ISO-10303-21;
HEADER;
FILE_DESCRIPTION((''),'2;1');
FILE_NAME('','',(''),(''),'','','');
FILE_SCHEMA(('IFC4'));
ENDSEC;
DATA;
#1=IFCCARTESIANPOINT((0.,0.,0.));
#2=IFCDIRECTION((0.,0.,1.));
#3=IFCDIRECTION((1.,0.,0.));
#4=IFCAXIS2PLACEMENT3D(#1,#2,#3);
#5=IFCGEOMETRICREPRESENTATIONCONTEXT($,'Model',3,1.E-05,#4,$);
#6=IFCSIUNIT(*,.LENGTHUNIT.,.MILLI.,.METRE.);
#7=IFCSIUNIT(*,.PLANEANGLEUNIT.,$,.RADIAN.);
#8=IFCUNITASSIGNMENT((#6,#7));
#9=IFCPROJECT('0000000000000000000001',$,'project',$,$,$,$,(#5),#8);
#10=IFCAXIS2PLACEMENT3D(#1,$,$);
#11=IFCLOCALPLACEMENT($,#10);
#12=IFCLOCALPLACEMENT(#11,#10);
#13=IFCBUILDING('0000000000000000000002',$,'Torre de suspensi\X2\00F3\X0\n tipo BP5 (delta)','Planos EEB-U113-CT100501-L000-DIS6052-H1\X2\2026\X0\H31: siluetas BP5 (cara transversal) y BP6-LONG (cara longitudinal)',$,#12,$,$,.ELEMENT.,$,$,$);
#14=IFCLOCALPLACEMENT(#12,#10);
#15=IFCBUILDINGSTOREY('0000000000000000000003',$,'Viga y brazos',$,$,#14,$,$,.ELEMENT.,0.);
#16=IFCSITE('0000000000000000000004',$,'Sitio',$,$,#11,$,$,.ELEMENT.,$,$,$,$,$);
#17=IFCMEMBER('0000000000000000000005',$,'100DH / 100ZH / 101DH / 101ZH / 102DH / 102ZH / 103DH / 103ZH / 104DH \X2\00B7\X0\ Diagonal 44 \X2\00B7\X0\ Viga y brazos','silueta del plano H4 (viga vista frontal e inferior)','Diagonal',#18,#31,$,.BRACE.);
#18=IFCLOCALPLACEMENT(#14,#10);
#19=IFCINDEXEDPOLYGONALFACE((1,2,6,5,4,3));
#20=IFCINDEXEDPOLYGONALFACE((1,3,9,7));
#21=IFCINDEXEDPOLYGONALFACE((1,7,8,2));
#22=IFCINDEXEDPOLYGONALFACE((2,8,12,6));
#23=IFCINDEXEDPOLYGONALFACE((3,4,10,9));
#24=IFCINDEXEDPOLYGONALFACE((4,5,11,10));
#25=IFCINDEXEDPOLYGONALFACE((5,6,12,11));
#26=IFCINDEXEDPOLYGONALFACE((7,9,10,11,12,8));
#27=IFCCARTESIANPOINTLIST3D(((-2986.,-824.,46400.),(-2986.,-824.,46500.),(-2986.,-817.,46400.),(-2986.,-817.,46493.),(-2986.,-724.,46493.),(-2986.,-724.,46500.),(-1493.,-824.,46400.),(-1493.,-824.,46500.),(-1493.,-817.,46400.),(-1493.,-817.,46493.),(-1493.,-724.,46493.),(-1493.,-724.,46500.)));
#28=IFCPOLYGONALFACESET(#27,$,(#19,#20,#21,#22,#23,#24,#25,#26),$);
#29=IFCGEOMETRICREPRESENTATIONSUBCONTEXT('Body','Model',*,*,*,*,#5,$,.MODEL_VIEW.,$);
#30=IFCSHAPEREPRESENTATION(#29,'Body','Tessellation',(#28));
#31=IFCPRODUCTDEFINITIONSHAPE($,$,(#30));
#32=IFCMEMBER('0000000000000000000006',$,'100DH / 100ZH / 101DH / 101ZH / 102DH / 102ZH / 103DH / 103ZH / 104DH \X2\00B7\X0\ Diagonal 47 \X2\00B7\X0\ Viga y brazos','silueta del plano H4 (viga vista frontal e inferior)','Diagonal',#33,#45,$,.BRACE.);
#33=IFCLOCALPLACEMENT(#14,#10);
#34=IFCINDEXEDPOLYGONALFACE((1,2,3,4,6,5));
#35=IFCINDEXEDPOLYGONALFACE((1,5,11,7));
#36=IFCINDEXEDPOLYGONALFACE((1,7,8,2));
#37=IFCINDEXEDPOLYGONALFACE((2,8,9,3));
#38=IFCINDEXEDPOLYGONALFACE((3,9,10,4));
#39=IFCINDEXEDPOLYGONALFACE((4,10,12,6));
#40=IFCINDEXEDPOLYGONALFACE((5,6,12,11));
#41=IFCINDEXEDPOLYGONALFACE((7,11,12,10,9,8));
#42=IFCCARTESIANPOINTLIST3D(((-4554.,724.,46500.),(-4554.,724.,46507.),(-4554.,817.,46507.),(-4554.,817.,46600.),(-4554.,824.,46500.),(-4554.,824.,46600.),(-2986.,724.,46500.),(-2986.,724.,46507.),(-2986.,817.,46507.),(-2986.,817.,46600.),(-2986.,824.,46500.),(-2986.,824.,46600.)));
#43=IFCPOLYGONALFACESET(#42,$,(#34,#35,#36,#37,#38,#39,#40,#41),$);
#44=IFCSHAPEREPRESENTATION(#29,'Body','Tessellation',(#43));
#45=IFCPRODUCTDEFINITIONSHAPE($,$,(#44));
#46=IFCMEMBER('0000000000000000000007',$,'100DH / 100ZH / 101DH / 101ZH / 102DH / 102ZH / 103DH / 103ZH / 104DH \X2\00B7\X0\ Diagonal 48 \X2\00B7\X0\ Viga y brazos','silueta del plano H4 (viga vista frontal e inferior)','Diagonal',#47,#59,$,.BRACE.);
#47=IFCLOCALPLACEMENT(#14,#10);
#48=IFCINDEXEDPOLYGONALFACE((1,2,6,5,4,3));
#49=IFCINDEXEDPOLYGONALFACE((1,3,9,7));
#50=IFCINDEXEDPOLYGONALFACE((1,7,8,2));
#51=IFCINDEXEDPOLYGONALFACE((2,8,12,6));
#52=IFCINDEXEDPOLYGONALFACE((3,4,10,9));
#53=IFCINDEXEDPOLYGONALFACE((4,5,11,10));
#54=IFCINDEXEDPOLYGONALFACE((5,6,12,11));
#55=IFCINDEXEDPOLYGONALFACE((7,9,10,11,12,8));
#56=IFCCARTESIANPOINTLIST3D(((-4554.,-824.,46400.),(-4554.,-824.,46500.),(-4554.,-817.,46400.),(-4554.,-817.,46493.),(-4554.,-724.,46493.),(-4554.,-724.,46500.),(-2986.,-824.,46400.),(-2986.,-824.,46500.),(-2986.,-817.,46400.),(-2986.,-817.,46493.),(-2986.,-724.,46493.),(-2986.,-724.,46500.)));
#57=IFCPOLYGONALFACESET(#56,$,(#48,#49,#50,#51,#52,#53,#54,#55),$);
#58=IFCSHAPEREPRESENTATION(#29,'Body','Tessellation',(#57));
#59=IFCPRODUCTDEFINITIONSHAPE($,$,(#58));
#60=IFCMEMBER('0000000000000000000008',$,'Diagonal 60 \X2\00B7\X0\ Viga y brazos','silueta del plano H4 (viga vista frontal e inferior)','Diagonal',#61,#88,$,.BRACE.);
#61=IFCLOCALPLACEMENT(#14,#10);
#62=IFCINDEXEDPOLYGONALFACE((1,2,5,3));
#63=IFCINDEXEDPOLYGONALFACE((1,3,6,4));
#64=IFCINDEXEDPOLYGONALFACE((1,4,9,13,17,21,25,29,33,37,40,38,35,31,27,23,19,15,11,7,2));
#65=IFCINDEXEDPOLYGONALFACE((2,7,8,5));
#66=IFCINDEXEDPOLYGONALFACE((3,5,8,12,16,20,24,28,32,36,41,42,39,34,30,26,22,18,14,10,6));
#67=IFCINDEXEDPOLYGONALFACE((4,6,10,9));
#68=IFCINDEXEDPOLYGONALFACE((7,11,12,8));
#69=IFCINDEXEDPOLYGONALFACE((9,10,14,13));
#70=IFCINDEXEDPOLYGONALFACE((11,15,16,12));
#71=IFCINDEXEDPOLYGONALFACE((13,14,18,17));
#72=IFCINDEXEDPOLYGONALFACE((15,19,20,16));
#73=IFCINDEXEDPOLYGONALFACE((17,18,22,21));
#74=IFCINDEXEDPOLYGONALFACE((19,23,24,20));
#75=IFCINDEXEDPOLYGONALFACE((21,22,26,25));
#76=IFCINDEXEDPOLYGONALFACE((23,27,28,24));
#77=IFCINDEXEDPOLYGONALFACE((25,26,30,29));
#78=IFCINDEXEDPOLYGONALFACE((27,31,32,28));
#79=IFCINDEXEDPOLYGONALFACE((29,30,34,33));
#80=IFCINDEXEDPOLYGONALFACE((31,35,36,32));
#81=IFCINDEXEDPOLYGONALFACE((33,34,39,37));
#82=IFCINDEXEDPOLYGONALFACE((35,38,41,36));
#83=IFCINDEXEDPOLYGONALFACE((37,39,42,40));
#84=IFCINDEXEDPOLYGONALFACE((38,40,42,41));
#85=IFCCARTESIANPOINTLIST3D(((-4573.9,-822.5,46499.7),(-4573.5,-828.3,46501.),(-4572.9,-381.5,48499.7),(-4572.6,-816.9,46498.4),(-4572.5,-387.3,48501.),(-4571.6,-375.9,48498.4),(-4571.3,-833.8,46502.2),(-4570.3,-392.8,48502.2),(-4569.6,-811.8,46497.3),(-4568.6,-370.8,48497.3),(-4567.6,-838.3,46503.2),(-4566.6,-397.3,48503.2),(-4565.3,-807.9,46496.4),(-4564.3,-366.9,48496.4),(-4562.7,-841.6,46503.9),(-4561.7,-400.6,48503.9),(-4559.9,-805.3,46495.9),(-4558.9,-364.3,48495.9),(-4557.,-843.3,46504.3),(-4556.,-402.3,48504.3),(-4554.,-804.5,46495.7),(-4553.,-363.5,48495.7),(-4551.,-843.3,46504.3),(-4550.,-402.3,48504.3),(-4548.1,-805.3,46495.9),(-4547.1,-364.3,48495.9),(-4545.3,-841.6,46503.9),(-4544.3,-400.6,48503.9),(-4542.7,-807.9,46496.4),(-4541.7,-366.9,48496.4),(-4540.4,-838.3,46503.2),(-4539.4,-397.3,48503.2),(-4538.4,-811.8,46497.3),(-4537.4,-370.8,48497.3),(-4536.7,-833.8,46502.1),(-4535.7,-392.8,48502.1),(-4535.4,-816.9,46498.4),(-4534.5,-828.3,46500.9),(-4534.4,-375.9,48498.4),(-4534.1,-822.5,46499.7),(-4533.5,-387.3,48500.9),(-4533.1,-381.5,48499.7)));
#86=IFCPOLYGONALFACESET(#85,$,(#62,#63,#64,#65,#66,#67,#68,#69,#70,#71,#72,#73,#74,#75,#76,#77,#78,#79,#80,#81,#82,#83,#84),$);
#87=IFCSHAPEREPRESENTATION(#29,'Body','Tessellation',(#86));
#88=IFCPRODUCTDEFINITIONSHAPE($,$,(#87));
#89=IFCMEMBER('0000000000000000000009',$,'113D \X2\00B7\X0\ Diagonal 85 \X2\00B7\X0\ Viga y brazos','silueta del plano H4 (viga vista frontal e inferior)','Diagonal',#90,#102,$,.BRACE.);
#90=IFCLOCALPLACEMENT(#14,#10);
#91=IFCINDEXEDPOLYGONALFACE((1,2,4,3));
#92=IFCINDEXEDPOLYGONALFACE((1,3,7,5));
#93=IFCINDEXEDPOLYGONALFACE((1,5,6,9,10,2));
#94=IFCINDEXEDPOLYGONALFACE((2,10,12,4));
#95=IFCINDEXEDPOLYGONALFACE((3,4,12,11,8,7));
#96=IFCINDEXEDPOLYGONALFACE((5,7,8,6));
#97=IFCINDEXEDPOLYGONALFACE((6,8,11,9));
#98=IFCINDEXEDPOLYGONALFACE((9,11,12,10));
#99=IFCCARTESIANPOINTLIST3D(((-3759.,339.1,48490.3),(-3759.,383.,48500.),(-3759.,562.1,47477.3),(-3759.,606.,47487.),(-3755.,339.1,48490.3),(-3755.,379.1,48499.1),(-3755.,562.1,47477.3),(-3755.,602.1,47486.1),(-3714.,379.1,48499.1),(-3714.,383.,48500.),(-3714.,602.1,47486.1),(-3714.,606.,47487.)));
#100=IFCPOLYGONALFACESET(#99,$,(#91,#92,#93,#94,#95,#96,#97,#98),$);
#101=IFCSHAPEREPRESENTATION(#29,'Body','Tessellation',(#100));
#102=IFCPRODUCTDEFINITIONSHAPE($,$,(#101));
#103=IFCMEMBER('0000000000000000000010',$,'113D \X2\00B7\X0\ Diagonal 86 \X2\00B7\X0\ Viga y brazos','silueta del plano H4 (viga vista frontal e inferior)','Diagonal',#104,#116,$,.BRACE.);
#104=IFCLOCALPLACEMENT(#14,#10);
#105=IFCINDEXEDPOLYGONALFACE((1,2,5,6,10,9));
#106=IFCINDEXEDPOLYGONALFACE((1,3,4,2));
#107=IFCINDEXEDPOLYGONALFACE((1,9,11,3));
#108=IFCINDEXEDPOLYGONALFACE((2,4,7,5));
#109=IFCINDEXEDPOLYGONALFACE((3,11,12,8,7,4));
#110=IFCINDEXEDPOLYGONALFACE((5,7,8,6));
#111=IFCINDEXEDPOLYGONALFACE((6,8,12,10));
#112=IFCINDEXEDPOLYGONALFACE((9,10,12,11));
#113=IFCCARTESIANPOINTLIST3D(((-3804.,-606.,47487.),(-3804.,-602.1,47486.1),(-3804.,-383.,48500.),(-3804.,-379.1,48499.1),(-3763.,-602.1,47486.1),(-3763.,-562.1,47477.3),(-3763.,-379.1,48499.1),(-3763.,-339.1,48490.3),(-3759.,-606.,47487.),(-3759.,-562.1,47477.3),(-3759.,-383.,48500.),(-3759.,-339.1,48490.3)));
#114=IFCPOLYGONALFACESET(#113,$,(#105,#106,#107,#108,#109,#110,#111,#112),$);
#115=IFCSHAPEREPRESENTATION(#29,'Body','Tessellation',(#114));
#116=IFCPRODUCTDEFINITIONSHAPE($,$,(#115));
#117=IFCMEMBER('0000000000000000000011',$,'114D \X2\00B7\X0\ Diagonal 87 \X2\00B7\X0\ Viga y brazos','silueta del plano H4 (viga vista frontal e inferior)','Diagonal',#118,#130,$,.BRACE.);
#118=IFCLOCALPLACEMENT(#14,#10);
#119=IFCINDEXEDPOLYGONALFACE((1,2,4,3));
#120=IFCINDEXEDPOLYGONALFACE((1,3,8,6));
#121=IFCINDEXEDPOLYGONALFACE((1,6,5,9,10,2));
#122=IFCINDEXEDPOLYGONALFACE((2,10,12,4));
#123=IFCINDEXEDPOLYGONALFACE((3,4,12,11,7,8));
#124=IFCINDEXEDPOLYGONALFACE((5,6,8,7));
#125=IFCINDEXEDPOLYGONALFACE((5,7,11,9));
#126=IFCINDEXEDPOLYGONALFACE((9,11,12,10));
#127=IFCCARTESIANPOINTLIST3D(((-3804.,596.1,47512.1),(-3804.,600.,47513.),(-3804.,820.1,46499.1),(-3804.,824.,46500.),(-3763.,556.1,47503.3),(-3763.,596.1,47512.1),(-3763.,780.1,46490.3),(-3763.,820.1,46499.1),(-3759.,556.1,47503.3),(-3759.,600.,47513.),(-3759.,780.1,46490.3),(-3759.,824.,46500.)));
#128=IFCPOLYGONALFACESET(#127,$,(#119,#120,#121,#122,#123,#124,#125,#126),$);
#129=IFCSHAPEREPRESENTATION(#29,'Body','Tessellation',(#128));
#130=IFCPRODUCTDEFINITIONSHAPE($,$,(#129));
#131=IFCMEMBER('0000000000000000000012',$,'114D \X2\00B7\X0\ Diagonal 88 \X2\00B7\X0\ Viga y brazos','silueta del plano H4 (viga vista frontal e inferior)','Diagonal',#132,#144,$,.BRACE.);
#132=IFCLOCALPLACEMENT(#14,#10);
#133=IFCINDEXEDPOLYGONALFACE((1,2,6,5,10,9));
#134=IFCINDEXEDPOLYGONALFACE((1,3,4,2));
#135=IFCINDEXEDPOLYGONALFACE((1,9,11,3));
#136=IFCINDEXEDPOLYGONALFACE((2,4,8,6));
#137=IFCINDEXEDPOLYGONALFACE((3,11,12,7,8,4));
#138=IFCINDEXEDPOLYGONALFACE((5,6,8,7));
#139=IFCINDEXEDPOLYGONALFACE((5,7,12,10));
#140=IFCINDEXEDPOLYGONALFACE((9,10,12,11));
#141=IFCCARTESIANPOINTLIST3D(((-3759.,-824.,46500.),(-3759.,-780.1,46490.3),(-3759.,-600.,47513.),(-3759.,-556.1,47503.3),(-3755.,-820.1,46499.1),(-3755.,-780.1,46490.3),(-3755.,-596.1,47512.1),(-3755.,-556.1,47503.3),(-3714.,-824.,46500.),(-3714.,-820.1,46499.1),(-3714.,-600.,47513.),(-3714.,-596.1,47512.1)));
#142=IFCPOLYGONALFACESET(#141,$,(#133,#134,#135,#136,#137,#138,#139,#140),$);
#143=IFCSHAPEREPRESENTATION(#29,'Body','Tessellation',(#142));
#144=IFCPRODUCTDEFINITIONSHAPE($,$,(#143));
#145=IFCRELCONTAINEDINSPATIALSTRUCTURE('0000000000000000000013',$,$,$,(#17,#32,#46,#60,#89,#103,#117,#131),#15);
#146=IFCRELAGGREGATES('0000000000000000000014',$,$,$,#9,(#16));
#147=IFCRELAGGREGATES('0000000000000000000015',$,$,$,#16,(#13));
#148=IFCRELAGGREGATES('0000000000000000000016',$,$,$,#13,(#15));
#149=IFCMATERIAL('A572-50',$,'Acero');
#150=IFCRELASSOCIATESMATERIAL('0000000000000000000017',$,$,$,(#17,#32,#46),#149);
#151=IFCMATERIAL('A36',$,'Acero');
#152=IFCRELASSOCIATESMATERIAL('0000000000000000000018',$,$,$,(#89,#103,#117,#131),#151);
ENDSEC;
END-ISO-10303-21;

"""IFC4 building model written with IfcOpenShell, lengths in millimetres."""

from ifc_helpers import new_model, si_unit, frame, frame_2d, origin, origin_with_axes, place, context, subcontext, project, spatial, circle, l_section, extrude, material, element, save


model = new_model("IFC4")

# Units and contexts
model_context = context("Model", 3, precision=1e-05, world=origin_with_axes())
body_context = subcontext(model_context, "Body", "Model", "MODEL_VIEW")
ifc_project = project(units=[si_unit("LENGTHUNIT", "METRE", prefix="MILLI"), si_unit("PLANEANGLEUNIT", "RADIAN")], contexts=[model_context])

# Site, building, storey
site_placement = place(None, origin())
site = spatial("IfcSite", under=ifc_project, at=site_placement, Name="Sitio", CompositionType="ELEMENT")
building_placement = place(site_placement, origin())
building = spatial("IfcBuilding", under=site, at=building_placement, Name="Torre de suspensión tipo BP5 (delta)", Description="Planos EEB-U113-CT100501-L000-DIS6052-H1…H31: siluetas BP5 (cara transversal) y BP6-LONG (cara longitudinal)", CompositionType="ELEMENT")
storey_placement = place(building_placement, origin())
storey = spatial("IfcBuildingStorey", under=building, at=storey_placement, Name="Viga y brazos", CompositionType="ELEMENT", Elevation=0.0)

# Members
ifc_material_1 = material(Name="A572-50", Category="Acero")
for number, where, z_axis, x_axis, name in (
    (1, (-1493.0, -824.0, 46500.0), (-1.0, 0.0, 0.0), (0.0, 1.0, 0.0), "100DH / 100ZH / 101DH / 101ZH / 102DH / 102ZH / 103DH / 103ZH / 104DH · Diagonal 44 · Viga y brazos"),
):
    element("IfcMember", number, at=place(storey_placement, frame(where, z_axis=z_axis, x_axis=x_axis)), inside=storey, material=ifc_material_1, Name=name, Description="silueta del plano H4 (viga vista frontal e inferior)", ObjectType="Diagonal", PredefinedType="BRACE", context=body_context, shape_type="SweptSolid", body=[
        extrude(l_section(Depth=100.0, Width=100.0, Thickness=7.0, at=frame_2d((50.0, 50.0))), None, (0.0, 0.0, 1.0), 1493.0),
    ])
for number, where, z_axis, x_axis, name in (
    (2, (-2986.0, 824.0, 46500.0), (-1.0, 0.0, 0.0), (0.0, -1.0, 0.0), "100DH / 100ZH / 101DH / 101ZH / 102DH / 102ZH / 103DH / 103ZH / 104DH · Diagonal 47 · Viga y brazos"),
    (3, (-2986.0, -824.0, 46500.0), (-1.0, 0.0, 0.0), (0.0, 1.0, 0.0), "100DH / 100ZH / 101DH / 101ZH / 102DH / 102ZH / 103DH / 103ZH / 104DH · Diagonal 48 · Viga y brazos"),
):
    element("IfcMember", number, at=place(storey_placement, frame(where, z_axis=z_axis, x_axis=x_axis)), inside=storey, material=ifc_material_1, Name=name, Description="silueta del plano H4 (viga vista frontal e inferior)", ObjectType="Diagonal", PredefinedType="BRACE", context=body_context, shape_type="SweptSolid", body=[
        extrude(l_section(Depth=100.0, Width=100.0, Thickness=7.0, at=frame_2d((50.0, 50.0))), None, (0.0, 0.0, 1.0), 1568.0),
    ])
member_placement = place(storey_placement, frame((-4553.0, -383.0, 48500.0), z_axis=(-0.000488, -0.215327, -0.976542), x_axis=(-0.000108, 0.976542, -0.215327)))
element("IfcMember", 4, at=member_placement, inside=storey, Name="Diagonal 60 · Viga y brazos", Description="silueta del plano H4 (viga vista frontal e inferior)", ObjectType="Diagonal", PredefinedType="BRACE", context=body_context, shape_type="SweptSolid", body=[
    extrude(circle(Radius=20.0), None, (0.0, 0.0, 1.0), 2048.0),
])
ifc_material_2 = material(Name="A36", Category="Acero")
for number, where, z_axis, x_axis, name in (
    (5, (-3759.0, 606.0, 47487.0), (0.0, -0.214991, 0.976616), (0.0, -0.976616, -0.214991), "113D · Diagonal 85 · Viga y brazos"),
    (6, (-3759.0, -606.0, 47487.0), (0.0, 0.214991, 0.976616), (0.0, 0.976616, -0.214991), "113D · Diagonal 86 · Viga y brazos"),
):
    element("IfcMember", number, at=place(storey_placement, frame(where, z_axis=z_axis, x_axis=x_axis)), inside=storey, material=ifc_material_2, Name=name, Description="silueta del plano H4 (viga vista frontal e inferior)", ObjectType="Diagonal", PredefinedType="BRACE", context=body_context, shape_type="SweptSolid", body=[
        extrude(l_section(Depth=45.0, Width=45.0, Thickness=4.0, at=frame_2d((22.5, 22.5))), None, (0.0, 0.0, 1.0), 1037.3),
    ])
for number, where, z_axis, x_axis, name in (
    (7, (-3759.0, 600.0, 47513.0), (0.0, 0.21591, -0.976413), (0.0, -0.976413, -0.21591), "114D · Diagonal 87 · Viga y brazos"),
    (8, (-3759.0, -600.0, 47513.0), (0.0, -0.21591, -0.976413), (0.0, 0.976413, -0.21591), "114D · Diagonal 88 · Viga y brazos"),
):
    element("IfcMember", number, at=place(storey_placement, frame(where, z_axis=z_axis, x_axis=x_axis)), inside=storey, material=ifc_material_2, Name=name, Description="silueta del plano H4 (viga vista frontal e inferior)", ObjectType="Diagonal", PredefinedType="BRACE", context=body_context, shape_type="SweptSolid", body=[
        extrude(l_section(Depth=45.0, Width=45.0, Thickness=4.0, at=frame_2d((22.5, 22.5))), None, (0.0, 0.0, 1.0), 1037.5),
    ])

save(model, "model.ifc")
